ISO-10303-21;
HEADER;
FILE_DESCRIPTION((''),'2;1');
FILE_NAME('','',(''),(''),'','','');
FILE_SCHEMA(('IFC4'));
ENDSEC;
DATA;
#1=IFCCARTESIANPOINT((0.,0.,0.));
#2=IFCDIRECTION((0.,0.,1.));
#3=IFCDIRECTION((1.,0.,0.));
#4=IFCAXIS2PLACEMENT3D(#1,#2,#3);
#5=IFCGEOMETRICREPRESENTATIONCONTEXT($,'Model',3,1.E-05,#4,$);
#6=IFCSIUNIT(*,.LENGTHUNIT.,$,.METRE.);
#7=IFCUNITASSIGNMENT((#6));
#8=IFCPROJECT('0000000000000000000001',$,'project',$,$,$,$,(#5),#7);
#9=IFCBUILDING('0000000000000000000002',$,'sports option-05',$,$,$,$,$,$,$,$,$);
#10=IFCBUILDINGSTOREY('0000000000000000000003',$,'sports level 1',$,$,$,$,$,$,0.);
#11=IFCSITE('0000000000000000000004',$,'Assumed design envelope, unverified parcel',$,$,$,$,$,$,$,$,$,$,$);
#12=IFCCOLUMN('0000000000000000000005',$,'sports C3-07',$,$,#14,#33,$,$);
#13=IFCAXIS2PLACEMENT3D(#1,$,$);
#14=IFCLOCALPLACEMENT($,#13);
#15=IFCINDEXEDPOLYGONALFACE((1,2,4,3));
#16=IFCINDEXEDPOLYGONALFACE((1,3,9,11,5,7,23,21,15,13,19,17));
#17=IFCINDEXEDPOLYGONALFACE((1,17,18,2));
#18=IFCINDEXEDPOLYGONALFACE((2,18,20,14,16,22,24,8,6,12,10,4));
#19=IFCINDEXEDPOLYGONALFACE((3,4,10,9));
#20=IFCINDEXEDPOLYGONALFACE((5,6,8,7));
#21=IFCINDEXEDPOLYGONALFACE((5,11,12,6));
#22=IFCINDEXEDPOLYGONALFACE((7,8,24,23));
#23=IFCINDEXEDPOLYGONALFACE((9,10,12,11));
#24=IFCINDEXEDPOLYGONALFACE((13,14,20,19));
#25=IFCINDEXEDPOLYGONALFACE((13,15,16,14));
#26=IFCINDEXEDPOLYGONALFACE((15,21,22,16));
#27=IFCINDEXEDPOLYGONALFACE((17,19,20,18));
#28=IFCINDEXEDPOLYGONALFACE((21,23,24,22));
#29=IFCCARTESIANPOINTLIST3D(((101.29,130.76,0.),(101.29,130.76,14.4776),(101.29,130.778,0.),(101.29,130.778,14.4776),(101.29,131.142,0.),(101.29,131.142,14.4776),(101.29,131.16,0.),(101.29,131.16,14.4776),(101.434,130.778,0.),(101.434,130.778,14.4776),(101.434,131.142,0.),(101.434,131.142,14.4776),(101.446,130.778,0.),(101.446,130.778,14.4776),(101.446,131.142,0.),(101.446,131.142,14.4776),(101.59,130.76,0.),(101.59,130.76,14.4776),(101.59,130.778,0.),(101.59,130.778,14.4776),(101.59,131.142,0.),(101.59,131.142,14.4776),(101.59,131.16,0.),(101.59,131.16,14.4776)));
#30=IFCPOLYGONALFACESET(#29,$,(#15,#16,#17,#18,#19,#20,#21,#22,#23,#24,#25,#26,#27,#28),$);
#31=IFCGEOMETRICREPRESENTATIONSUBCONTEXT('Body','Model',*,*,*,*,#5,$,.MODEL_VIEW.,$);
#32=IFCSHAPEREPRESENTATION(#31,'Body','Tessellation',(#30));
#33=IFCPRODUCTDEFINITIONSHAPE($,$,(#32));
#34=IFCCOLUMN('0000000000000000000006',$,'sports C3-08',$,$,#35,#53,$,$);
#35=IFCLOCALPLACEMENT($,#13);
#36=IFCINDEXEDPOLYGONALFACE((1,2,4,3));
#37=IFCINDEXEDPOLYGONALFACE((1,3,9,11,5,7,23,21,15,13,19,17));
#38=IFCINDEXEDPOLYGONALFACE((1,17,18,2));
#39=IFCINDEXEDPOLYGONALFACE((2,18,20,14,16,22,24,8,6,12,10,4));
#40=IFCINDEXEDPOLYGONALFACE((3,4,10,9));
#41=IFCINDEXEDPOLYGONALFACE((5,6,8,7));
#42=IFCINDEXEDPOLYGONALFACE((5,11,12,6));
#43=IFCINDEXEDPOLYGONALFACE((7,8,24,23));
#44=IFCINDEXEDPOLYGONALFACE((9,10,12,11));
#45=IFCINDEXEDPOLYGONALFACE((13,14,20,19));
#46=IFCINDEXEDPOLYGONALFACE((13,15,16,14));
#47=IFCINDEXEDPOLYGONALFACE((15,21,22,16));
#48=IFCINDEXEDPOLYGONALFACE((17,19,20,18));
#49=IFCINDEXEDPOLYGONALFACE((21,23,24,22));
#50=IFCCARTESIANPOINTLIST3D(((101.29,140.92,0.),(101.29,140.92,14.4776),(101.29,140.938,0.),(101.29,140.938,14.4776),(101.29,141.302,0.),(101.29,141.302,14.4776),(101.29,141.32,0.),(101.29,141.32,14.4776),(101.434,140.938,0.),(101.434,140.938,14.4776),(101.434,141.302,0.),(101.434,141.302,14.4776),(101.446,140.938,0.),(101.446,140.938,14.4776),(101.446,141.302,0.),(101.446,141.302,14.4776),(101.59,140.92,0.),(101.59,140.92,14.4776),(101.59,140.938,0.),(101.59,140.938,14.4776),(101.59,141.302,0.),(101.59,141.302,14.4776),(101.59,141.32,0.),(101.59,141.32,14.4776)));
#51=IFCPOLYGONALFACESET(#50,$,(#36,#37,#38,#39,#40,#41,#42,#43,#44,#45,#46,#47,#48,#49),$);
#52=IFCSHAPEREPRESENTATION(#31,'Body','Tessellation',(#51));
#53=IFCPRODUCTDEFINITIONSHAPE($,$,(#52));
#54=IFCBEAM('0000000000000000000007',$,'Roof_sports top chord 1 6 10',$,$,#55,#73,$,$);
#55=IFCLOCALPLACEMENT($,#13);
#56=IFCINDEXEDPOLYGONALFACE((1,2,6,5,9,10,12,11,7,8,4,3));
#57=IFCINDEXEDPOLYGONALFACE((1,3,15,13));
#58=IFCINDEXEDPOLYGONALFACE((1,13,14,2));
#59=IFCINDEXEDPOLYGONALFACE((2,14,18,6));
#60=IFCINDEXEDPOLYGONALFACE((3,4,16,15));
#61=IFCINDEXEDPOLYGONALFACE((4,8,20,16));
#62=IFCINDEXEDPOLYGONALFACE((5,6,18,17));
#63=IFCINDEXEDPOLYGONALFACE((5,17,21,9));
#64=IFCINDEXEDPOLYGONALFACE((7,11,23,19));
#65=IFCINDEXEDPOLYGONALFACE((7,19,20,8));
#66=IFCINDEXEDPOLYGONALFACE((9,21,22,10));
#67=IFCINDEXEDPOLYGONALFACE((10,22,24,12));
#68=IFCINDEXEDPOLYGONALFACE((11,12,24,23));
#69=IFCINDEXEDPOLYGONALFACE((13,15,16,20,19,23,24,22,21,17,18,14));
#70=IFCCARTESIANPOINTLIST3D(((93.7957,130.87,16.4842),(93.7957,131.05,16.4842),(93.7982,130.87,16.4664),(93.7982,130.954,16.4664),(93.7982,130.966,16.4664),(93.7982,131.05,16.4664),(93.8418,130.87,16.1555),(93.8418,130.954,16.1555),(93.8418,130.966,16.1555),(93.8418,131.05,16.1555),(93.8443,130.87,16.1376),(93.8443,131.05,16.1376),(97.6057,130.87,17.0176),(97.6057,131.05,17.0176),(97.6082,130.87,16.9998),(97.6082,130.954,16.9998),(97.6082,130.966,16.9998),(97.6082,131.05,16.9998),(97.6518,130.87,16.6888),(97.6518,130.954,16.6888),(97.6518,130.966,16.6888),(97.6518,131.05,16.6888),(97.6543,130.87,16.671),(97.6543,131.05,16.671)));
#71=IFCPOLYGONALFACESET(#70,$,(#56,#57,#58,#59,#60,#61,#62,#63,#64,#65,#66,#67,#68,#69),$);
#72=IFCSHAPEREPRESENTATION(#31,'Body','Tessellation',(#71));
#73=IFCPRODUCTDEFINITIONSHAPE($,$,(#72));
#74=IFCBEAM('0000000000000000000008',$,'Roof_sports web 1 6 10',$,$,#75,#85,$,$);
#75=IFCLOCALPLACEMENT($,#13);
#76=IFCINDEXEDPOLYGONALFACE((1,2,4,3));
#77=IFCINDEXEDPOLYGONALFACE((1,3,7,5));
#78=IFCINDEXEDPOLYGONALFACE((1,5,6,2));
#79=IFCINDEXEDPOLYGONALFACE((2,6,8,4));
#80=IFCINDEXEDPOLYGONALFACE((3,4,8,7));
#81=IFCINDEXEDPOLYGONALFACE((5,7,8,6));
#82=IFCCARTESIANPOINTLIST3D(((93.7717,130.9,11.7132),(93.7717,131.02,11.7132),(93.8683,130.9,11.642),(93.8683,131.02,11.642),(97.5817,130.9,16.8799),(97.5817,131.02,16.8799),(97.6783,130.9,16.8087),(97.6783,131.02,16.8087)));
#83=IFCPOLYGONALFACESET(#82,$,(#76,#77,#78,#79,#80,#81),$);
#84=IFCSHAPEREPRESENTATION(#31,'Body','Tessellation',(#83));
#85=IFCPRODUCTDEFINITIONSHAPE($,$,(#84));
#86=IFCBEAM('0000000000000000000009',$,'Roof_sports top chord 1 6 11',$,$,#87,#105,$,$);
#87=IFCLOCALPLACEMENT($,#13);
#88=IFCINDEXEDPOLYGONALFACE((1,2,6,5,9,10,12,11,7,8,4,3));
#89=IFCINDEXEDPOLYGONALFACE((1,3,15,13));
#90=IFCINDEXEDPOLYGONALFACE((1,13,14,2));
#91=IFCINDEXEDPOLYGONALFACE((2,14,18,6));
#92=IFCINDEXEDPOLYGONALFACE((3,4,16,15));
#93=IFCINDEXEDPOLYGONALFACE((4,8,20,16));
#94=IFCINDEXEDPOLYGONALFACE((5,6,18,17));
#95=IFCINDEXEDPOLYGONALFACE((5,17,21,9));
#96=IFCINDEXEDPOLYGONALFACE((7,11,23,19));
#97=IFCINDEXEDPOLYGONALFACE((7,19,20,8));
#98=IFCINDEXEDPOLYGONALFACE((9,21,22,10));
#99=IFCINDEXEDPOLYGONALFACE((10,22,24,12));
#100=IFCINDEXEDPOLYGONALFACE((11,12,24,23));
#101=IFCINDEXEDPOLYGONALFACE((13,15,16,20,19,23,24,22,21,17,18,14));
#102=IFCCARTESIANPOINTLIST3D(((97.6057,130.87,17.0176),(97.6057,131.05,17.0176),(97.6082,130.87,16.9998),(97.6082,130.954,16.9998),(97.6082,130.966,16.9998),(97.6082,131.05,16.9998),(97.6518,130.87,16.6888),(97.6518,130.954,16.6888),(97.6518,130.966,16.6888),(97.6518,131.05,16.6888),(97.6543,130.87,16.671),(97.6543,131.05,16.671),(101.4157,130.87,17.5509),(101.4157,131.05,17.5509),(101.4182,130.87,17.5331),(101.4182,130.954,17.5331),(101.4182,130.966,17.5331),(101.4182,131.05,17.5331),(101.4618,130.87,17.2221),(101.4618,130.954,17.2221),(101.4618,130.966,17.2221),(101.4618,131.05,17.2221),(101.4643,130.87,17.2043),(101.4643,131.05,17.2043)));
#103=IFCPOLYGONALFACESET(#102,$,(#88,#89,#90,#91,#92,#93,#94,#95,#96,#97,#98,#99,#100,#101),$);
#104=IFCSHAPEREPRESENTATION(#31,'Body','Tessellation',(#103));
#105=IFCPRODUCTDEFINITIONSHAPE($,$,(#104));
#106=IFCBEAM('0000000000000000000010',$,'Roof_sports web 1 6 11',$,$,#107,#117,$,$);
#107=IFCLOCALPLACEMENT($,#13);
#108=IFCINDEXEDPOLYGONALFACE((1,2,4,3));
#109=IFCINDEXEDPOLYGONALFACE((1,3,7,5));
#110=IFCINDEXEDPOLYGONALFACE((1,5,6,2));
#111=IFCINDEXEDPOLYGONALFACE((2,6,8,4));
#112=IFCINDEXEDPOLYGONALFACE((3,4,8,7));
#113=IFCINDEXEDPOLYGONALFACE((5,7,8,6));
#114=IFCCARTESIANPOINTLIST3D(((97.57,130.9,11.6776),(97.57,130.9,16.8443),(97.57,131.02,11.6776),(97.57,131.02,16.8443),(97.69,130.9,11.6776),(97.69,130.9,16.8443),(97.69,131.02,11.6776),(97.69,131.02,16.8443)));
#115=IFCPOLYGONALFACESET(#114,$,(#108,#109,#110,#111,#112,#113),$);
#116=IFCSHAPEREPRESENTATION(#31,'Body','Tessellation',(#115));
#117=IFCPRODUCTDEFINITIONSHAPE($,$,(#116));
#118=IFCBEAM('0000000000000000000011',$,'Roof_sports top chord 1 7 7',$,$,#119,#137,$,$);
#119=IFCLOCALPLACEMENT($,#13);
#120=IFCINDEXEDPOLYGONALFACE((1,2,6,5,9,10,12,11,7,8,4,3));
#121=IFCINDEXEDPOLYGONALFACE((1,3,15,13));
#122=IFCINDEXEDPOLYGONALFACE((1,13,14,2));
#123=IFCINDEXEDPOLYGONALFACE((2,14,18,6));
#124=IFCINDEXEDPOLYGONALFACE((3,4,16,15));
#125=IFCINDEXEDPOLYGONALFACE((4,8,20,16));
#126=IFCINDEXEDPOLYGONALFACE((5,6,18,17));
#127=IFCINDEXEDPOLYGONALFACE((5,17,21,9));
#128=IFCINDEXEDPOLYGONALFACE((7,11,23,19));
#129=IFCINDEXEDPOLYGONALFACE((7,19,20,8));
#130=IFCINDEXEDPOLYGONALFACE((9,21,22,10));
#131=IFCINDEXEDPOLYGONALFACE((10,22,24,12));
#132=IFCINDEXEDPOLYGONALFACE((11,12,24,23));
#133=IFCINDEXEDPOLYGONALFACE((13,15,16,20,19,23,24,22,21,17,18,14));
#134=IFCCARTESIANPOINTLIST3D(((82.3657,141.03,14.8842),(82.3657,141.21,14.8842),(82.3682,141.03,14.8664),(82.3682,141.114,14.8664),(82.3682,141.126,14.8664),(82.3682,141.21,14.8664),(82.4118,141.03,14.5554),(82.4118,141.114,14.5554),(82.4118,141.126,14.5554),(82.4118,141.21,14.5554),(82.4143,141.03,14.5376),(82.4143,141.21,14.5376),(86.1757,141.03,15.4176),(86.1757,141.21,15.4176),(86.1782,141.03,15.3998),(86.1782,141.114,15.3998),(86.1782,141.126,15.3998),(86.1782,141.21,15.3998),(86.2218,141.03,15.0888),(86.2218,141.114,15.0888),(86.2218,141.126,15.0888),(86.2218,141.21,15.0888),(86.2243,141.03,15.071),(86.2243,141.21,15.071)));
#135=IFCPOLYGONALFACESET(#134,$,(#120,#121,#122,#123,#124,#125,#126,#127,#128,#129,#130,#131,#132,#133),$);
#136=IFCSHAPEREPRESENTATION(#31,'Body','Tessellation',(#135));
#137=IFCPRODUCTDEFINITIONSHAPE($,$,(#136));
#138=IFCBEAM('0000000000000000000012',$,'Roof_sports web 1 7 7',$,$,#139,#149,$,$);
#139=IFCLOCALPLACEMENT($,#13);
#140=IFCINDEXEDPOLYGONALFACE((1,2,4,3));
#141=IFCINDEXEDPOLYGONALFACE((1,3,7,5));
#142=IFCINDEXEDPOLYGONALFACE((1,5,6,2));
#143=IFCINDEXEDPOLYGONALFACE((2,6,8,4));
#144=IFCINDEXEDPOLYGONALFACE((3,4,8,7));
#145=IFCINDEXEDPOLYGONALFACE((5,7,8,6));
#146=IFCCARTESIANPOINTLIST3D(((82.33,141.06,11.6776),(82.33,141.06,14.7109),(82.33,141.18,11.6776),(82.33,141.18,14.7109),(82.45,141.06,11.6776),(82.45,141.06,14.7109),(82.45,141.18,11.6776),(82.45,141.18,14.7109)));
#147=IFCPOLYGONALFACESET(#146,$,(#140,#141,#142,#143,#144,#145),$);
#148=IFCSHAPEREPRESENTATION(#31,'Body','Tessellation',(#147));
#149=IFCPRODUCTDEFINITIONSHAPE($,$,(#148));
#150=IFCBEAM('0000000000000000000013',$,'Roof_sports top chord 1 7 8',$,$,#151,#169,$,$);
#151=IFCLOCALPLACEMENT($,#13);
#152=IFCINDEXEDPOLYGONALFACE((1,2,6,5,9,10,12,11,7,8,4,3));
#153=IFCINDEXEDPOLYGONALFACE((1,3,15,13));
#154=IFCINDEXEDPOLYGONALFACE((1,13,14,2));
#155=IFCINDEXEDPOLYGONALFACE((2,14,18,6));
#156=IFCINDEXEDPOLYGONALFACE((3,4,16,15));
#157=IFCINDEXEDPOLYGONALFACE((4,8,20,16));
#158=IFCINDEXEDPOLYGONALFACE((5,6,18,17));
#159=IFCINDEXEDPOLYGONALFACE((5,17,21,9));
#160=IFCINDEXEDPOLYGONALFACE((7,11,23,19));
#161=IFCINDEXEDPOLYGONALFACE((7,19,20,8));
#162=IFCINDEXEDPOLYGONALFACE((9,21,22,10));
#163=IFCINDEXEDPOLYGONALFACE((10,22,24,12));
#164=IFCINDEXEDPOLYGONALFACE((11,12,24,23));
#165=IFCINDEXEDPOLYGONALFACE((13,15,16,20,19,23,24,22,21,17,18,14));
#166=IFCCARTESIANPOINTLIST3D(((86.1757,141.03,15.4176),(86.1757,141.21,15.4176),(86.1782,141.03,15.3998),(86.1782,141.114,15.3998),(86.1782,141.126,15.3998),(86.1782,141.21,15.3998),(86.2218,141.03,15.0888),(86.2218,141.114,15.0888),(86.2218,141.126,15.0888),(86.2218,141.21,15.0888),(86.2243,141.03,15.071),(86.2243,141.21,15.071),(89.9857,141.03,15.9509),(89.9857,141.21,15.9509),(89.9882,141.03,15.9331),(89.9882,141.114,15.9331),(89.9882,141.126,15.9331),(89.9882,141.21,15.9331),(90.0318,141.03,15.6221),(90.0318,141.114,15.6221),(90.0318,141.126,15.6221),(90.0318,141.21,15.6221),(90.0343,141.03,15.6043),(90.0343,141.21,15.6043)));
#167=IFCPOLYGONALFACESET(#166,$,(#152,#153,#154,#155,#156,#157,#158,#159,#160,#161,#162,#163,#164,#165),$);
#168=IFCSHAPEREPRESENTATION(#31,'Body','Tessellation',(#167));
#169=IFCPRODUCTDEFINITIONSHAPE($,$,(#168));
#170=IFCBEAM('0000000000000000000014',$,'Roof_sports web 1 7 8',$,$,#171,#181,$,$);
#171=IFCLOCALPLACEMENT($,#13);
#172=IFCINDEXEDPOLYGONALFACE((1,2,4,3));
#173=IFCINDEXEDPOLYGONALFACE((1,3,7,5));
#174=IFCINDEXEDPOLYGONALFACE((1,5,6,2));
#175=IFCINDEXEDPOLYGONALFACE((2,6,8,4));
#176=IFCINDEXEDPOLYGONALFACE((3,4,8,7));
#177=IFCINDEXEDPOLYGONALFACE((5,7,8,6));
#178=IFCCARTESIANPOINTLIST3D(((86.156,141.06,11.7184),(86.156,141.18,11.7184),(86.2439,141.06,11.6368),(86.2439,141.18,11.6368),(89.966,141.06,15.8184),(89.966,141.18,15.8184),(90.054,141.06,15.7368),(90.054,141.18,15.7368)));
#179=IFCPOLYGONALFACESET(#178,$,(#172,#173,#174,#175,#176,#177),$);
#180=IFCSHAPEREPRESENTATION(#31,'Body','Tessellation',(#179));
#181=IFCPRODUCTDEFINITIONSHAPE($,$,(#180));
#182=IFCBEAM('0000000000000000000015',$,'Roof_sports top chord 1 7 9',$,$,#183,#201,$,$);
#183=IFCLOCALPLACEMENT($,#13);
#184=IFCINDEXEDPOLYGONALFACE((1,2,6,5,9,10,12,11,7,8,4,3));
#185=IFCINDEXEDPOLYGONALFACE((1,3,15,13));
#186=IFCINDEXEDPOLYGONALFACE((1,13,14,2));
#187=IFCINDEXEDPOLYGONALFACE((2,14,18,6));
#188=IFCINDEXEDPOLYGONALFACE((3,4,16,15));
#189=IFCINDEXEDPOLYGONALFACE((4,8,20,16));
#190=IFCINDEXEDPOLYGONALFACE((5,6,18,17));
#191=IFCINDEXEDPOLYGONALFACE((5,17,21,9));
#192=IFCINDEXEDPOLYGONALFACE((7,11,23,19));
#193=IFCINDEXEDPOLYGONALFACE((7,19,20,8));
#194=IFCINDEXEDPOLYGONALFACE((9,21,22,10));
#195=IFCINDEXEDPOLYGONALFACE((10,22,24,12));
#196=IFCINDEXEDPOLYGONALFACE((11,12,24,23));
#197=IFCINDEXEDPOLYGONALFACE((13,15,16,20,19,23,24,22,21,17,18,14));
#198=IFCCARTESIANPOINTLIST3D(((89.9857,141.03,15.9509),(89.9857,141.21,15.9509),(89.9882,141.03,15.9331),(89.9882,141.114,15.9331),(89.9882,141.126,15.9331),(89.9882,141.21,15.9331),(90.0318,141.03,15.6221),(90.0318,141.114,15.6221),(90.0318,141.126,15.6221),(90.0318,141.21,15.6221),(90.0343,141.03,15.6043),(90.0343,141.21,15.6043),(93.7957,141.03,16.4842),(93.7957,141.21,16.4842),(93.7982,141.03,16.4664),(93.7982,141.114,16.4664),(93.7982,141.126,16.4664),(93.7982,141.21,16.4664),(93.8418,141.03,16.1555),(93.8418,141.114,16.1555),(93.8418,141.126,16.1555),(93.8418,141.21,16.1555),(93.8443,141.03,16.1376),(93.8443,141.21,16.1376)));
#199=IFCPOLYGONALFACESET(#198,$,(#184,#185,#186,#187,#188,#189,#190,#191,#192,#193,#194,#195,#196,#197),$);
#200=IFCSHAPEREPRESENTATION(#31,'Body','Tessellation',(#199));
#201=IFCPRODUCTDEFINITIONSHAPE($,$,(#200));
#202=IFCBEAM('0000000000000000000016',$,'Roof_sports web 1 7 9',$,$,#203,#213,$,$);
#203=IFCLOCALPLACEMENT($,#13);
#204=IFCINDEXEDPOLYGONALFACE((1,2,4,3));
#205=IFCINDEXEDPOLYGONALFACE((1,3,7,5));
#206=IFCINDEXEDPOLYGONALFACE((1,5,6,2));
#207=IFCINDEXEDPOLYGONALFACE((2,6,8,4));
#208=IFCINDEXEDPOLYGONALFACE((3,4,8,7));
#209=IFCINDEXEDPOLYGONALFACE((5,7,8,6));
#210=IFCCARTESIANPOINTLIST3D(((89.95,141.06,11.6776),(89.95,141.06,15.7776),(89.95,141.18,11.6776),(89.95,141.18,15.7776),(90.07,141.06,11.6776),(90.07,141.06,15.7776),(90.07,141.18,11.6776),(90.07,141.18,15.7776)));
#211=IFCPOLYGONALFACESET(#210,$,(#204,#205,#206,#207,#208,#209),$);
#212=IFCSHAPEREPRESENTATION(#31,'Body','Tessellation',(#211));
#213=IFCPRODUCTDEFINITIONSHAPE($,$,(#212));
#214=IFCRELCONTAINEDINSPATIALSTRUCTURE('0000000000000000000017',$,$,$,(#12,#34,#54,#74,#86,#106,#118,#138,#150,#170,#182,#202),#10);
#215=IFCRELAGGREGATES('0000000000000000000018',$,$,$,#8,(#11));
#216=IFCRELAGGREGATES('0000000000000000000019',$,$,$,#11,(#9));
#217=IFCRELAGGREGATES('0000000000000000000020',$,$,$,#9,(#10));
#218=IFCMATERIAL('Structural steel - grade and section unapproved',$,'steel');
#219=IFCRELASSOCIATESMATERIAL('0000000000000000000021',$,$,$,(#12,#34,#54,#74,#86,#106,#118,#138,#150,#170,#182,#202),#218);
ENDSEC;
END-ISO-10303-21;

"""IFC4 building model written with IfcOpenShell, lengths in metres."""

from ifc_helpers import new_model, si_unit, frame, origin_with_axes, place, context, subcontext, project, spatial, rectangle, i_section, extrude, material, element, save


model = new_model("IFC4")

# Units and contexts
model_context = context("Model", 3, precision=1e-05, world=origin_with_axes())
body_context = subcontext(model_context, "Body", "Model", "MODEL_VIEW")
ifc_project = project(units=[si_unit("LENGTHUNIT", "METRE")], contexts=[model_context])

# Site, building, storey
site = spatial("IfcSite", under=ifc_project, Name="Assumed design envelope, unverified parcel")
building = spatial("IfcBuilding", under=site, Name="sports option-05")
storey = spatial("IfcBuildingStorey", under=building, Name="sports level 1", Elevation=0.0)

# Columns
ifc_material_1 = material(Name="Structural steel - grade and section unapproved", Category="steel")
for number, where, z_axis, x_axis, name in (
    (1, (101.44, 130.96, 0.0), (0.0, 0.0, 1.0), (-1.0, 0.0, 0.0), "sports C3-07"),
    (2, (101.44, 141.12, 0.0), (0.0, 0.0, 1.0), (-1.0, 0.0, 0.0), "sports C3-08"),
):
    element("IfcColumn", number, at=place(None, frame(where, z_axis=z_axis, x_axis=x_axis)), inside=storey, material=ifc_material_1, Name=name, context=body_context, shape_type="SweptSolid", body=[
        extrude(i_section(OverallWidth=0.3, OverallDepth=0.4, WebThickness=0.012, FlangeThickness=0.018, FilletRadius=0.0), origin_with_axes(), (0.0, 0.0, 1.0), 14.4776),
    ])

# Beams
beam_1_placement = place(None, frame((93.82, 130.96, 16.3109), z_axis=(0.990344, 0.0, 0.138631), x_axis=(0.0, 1.0, 0.0)))
element("IfcBeam", 3, at=beam_1_placement, inside=storey, material=ifc_material_1, Name="Roof_sports top chord 1 6 10", context=body_context, shape_type="SweptSolid", body=[
    extrude(i_section(OverallWidth=0.18, OverallDepth=0.35, WebThickness=0.012, FlangeThickness=0.018, FilletRadius=0.0), origin_with_axes(), (0.0, 0.0, 1.0), 3.8471),
])
beam_2_placement = place(None, frame((93.82, 130.96, 11.6776), z_axis=(0.5935, 0.0, 0.804834), x_axis=(0.0, 1.0, 0.0)))
element("IfcBeam", 4, at=beam_2_placement, inside=storey, material=ifc_material_1, Name="Roof_sports web 1 6 10", context=body_context, shape_type="SweptSolid", body=[
    extrude(rectangle(XDim=0.12, YDim=0.12), origin_with_axes(), (0.0, 0.0, 1.0), 6.4195),
])
beam_3_placement = place(None, frame((97.63, 130.96, 16.8443), z_axis=(0.990344, 0.0, 0.138631), x_axis=(0.0, 1.0, 0.0)))
element("IfcBeam", 5, at=beam_3_placement, inside=storey, material=ifc_material_1, Name="Roof_sports top chord 1 6 11", context=body_context, shape_type="SweptSolid", body=[
    extrude(i_section(OverallWidth=0.18, OverallDepth=0.35, WebThickness=0.012, FlangeThickness=0.018, FilletRadius=0.0), origin_with_axes(), (0.0, 0.0, 1.0), 3.8472),
])
beam_4_placement = place(None, frame((97.63, 130.96, 11.6776), z_axis=(0.0, 0.0, 1.0), x_axis=(-1.0, 0.0, 0.0)))
element("IfcBeam", 6, at=beam_4_placement, inside=storey, material=ifc_material_1, Name="Roof_sports web 1 6 11", context=body_context, shape_type="SweptSolid", body=[
    extrude(rectangle(XDim=0.12, YDim=0.12), origin_with_axes(), (0.0, 0.0, 1.0), 5.1667),
])
beam_5_placement = place(None, frame((82.39, 141.12, 14.7109), z_axis=(0.990344, 0.0, 0.138631), x_axis=(0.0, 1.0, 0.0)))
element("IfcBeam", 7, at=beam_5_placement, inside=storey, material=ifc_material_1, Name="Roof_sports top chord 1 7 7", context=body_context, shape_type="SweptSolid", body=[
    extrude(i_section(OverallWidth=0.18, OverallDepth=0.35, WebThickness=0.012, FlangeThickness=0.018, FilletRadius=0.0), origin_with_axes(), (0.0, 0.0, 1.0), 3.8471),
])
beam_6_placement = place(None, frame((82.39, 141.12, 11.6776), z_axis=(0.0, 0.0, 1.0), x_axis=(-1.0, 0.0, 0.0)))
element("IfcBeam", 8, at=beam_6_placement, inside=storey, material=ifc_material_1, Name="Roof_sports web 1 7 7", context=body_context, shape_type="SweptSolid", body=[
    extrude(rectangle(XDim=0.12, YDim=0.12), origin_with_axes(), (0.0, 0.0, 1.0), 3.0333),
])
beam_7_placement = place(None, frame((86.2, 141.12, 15.2443), z_axis=(0.990344, 0.0, 0.138631), x_axis=(0.0, 1.0, 0.0)))
element("IfcBeam", 9, at=beam_7_placement, inside=storey, material=ifc_material_1, Name="Roof_sports top chord 1 7 8", context=body_context, shape_type="SweptSolid", body=[
    extrude(i_section(OverallWidth=0.18, OverallDepth=0.35, WebThickness=0.012, FlangeThickness=0.018, FilletRadius=0.0), origin_with_axes(), (0.0, 0.0, 1.0), 3.8472),
])
beam_8_placement = place(None, frame((86.2, 141.12, 11.6776), z_axis=(0.680726, 0.0, 0.732538), x_axis=(0.0, 1.0, 0.0)))
element("IfcBeam", 10, at=beam_8_placement, inside=storey, material=ifc_material_1, Name="Roof_sports web 1 7 8", context=body_context, shape_type="SweptSolid", body=[
    extrude(rectangle(XDim=0.12, YDim=0.12), origin_with_axes(), (0.0, 0.0, 1.0), 5.597),
])
beam_9_placement = place(None, frame((90.01, 141.12, 15.7776), z_axis=(0.990344, 0.0, 0.138631), x_axis=(0.0, 1.0, 0.0)))
element("IfcBeam", 11, at=beam_9_placement, inside=storey, material=ifc_material_1, Name="Roof_sports top chord 1 7 9", context=body_context, shape_type="SweptSolid", body=[
    extrude(i_section(OverallWidth=0.18, OverallDepth=0.35, WebThickness=0.012, FlangeThickness=0.018, FilletRadius=0.0), origin_with_axes(), (0.0, 0.0, 1.0), 3.8471),
])
beam_10_placement = place(None, frame((90.01, 141.12, 11.6776), z_axis=(0.0, 0.0, 1.0), x_axis=(-1.0, 0.0, 0.0)))
element("IfcBeam", 12, at=beam_10_placement, inside=storey, material=ifc_material_1, Name="Roof_sports web 1 7 9", context=body_context, shape_type="SweptSolid", body=[
    extrude(rectangle(XDim=0.12, YDim=0.12), origin_with_axes(), (0.0, 0.0, 1.0), 4.1),
])

save(model, "model.ifc")
